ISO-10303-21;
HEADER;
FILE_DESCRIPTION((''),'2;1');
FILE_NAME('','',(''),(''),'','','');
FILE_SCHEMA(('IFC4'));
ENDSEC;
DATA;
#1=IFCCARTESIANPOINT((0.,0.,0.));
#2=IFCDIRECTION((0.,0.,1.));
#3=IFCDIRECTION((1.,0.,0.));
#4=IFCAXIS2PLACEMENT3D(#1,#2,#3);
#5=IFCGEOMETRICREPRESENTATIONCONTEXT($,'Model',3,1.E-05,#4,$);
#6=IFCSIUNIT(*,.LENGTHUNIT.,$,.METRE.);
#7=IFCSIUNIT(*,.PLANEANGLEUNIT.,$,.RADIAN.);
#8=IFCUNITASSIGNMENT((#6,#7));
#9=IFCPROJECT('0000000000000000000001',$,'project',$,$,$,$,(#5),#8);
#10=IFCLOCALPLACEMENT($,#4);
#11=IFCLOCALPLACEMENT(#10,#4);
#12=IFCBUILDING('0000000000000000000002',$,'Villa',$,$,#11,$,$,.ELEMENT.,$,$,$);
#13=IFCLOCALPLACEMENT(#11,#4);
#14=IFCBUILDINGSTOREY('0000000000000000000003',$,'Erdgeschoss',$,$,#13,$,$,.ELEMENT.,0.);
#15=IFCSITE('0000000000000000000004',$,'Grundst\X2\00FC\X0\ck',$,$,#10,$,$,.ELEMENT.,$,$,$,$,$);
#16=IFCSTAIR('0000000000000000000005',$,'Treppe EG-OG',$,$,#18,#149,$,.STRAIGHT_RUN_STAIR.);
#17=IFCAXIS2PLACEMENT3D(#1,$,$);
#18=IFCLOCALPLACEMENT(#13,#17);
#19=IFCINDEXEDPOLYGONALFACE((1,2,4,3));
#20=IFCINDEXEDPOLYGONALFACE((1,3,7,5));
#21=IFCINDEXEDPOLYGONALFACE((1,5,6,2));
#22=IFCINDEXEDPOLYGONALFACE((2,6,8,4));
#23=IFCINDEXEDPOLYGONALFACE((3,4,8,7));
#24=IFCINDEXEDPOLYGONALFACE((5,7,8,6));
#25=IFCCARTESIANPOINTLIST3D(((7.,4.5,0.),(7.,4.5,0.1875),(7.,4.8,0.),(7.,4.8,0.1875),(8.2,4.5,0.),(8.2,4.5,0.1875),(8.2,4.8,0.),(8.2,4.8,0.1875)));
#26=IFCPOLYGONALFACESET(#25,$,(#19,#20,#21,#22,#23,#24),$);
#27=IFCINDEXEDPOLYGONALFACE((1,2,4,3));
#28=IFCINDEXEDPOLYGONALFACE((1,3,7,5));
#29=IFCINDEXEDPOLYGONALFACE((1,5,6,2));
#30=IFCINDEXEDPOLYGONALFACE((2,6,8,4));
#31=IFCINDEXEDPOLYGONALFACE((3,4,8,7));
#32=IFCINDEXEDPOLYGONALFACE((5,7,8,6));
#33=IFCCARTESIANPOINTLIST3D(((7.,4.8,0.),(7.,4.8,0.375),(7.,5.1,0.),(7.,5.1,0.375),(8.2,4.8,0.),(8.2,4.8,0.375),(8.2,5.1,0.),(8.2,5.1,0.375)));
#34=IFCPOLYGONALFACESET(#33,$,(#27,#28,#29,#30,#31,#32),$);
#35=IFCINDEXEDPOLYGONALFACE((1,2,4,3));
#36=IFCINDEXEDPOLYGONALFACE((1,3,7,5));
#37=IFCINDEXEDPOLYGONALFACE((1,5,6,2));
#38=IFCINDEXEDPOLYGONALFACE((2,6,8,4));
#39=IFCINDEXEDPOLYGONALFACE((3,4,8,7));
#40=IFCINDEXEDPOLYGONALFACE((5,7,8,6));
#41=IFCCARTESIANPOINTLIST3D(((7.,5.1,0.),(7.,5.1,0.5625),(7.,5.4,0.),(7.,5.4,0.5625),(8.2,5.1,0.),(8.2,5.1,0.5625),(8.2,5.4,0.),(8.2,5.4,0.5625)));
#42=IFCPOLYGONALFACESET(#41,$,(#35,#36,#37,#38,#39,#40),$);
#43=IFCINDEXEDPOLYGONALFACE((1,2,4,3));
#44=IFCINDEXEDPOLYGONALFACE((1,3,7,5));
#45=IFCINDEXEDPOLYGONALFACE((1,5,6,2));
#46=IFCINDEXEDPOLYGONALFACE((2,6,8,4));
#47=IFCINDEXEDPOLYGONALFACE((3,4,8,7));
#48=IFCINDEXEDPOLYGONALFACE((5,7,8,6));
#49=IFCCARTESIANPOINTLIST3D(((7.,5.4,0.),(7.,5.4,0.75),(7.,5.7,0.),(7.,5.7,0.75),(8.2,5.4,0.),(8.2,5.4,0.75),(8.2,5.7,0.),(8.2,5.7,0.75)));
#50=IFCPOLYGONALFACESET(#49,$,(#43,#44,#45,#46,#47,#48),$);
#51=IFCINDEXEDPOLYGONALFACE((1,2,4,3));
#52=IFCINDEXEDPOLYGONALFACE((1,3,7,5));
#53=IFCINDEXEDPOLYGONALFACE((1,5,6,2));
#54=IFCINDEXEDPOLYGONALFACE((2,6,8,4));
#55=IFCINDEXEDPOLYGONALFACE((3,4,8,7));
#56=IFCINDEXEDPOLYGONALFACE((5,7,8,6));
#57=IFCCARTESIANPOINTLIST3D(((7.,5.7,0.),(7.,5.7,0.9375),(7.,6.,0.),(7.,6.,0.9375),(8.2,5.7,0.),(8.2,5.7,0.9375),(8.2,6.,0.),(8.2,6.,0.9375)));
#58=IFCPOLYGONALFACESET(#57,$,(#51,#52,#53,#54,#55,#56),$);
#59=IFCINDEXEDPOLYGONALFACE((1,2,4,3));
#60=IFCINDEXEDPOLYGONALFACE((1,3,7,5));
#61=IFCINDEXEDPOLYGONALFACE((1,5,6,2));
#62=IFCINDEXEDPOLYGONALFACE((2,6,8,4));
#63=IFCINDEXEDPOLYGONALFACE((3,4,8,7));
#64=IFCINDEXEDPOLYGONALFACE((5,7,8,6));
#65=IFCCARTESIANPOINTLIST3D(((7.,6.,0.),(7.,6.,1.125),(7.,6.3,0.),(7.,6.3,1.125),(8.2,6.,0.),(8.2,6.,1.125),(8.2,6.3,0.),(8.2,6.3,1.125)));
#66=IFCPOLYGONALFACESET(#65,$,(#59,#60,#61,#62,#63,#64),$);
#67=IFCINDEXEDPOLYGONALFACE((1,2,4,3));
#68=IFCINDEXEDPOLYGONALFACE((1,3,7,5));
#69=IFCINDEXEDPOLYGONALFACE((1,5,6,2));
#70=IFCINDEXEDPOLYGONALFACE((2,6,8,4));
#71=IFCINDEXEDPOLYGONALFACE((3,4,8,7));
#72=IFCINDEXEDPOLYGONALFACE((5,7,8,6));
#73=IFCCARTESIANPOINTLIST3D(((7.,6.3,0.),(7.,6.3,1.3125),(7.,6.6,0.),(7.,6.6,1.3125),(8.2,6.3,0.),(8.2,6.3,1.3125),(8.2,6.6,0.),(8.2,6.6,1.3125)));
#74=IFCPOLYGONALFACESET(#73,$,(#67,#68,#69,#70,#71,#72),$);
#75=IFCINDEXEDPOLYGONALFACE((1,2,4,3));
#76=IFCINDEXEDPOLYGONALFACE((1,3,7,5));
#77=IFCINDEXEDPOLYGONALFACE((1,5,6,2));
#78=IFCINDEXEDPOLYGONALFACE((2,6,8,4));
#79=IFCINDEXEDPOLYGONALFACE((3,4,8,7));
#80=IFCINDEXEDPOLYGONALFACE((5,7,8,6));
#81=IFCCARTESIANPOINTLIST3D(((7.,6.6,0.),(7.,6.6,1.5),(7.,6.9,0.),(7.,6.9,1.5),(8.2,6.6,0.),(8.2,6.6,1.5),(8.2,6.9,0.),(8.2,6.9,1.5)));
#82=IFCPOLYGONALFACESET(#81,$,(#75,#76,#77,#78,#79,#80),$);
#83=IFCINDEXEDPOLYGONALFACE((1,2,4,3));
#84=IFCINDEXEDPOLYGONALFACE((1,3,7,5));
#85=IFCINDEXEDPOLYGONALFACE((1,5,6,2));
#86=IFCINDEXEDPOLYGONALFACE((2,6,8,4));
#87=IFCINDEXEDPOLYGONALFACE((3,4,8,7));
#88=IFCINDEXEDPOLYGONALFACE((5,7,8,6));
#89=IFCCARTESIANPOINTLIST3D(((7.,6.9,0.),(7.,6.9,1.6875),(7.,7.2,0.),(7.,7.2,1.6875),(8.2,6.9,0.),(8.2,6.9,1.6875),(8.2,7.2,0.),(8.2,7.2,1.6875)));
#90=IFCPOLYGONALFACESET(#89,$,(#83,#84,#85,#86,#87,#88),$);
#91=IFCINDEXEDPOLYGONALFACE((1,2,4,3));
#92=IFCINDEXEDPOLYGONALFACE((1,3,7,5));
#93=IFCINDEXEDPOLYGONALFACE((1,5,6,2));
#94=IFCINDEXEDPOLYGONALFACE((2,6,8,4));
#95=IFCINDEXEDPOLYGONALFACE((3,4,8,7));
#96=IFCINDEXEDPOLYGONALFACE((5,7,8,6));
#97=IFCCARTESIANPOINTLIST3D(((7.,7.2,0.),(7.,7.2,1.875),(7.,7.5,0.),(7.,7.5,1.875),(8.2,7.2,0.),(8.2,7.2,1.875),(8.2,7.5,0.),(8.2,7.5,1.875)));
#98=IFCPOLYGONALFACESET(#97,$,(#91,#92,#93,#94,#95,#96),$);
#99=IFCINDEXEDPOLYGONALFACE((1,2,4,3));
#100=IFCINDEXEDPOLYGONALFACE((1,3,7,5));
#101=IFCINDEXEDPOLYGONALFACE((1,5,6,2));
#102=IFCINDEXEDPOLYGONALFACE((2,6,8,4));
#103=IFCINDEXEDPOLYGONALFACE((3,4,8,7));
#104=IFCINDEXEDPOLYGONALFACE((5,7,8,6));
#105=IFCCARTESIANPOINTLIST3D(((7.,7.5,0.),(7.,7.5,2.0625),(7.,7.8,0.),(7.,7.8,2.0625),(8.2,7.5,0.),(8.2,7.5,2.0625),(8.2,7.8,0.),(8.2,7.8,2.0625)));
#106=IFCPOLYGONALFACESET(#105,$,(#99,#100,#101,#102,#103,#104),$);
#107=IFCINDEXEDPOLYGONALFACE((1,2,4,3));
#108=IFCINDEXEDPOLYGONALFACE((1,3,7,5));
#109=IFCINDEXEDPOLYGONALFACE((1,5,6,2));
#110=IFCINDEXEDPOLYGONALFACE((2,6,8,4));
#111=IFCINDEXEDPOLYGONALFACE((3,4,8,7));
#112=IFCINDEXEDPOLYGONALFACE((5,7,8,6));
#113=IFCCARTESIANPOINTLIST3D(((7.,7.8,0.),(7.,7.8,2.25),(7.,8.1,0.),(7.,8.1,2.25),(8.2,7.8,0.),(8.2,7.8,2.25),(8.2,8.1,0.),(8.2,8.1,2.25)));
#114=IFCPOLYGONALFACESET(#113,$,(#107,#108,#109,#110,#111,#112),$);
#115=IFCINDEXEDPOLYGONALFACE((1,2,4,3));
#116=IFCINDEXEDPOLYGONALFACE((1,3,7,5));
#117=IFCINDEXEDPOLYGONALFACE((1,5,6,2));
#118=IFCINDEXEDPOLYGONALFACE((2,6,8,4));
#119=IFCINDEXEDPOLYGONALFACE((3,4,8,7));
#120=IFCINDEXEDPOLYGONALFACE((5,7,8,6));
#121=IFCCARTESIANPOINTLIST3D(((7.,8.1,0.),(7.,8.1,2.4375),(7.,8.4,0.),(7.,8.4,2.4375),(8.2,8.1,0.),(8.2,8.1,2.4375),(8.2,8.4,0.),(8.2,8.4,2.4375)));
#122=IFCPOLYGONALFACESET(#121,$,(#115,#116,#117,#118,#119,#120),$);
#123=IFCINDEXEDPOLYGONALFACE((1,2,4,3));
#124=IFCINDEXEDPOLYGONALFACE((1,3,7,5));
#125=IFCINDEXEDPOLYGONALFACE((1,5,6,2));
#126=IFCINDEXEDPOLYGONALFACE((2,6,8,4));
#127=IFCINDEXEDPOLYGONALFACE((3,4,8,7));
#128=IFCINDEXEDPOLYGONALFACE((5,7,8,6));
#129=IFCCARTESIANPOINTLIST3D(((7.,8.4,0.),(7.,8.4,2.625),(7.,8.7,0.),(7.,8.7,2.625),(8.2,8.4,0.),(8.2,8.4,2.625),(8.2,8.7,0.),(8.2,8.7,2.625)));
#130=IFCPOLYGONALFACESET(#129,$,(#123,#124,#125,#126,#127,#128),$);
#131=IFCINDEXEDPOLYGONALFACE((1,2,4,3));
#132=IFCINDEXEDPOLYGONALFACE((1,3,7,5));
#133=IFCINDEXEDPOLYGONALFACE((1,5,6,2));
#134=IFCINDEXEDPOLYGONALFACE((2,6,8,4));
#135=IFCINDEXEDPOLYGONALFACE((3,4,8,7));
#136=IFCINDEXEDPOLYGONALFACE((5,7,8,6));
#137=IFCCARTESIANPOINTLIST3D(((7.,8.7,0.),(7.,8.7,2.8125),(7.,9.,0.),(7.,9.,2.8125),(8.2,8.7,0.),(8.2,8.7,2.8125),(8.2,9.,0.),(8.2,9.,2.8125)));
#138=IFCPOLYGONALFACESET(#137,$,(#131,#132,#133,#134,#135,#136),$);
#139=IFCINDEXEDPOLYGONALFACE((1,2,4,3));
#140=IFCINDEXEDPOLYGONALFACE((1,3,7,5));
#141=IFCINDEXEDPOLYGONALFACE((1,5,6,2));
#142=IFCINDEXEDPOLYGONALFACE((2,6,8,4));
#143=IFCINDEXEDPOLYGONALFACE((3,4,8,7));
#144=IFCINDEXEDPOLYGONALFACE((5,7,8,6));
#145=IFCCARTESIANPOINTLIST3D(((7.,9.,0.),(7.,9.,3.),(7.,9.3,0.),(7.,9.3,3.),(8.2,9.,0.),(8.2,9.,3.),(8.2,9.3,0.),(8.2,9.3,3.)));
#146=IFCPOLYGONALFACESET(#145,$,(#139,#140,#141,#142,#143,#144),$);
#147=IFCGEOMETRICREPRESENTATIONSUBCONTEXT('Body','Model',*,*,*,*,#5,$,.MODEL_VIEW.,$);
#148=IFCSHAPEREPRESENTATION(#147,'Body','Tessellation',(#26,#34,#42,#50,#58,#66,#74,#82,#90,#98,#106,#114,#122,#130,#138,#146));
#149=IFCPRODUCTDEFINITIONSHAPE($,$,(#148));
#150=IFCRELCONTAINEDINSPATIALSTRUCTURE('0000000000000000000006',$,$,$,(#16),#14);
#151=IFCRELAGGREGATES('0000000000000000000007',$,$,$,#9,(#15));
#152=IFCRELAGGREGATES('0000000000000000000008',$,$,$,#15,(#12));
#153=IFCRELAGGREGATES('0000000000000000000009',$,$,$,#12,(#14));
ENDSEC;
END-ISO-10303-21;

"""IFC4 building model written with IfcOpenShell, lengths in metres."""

from ifc_helpers import new_model, si_unit, frame_2d, origin_with_axes, place, context, subcontext, project, spatial, rectangle, extrude, element, save


model = new_model("IFC4")

# Units and contexts
model_context = context("Model", 3, precision=1e-05, world=origin_with_axes())
body_context = subcontext(model_context, "Body", "Model", "MODEL_VIEW")
ifc_project = project(units=[si_unit("LENGTHUNIT", "METRE"), si_unit("PLANEANGLEUNIT", "RADIAN")], contexts=[model_context])

# Site, building, storey
site_placement = place(None, origin_with_axes())
site = spatial("IfcSite", under=ifc_project, at=site_placement, Name="Grundstück", CompositionType="ELEMENT")
building_placement = place(site_placement, origin_with_axes())
building = spatial("IfcBuilding", under=site, at=building_placement, Name="Villa", CompositionType="ELEMENT")
storey_placement = place(building_placement, origin_with_axes())
storey = spatial("IfcBuildingStorey", under=building, at=storey_placement, Name="Erdgeschoss", CompositionType="ELEMENT", Elevation=0.0)

# Stair
stair_placement = place(storey_placement, origin_with_axes())
element("IfcStair", 1, at=stair_placement, inside=storey, Name="Treppe EG-OG", PredefinedType="STRAIGHT_RUN_STAIR", context=body_context, shape_type="SweptSolid", body=[
    extrude(rectangle(XDim=1.2, YDim=0.3, at=frame_2d((7.6, 4.65))), origin_with_axes(), (0.0, 0.0, 1.0), 0.1875),
    extrude(rectangle(XDim=1.2, YDim=0.3, at=frame_2d((7.6, 4.95))), origin_with_axes(), (0.0, 0.0, 1.0), 0.375),
    extrude(rectangle(XDim=1.2, YDim=0.3, at=frame_2d((7.6, 5.25))), origin_with_axes(), (0.0, 0.0, 1.0), 0.5625),
    extrude(rectangle(XDim=1.2, YDim=0.3, at=frame_2d((7.6, 5.55))), origin_with_axes(), (0.0, 0.0, 1.0), 0.75),
    extrude(rectangle(XDim=1.2, YDim=0.3, at=frame_2d((7.6, 5.85))), origin_with_axes(), (0.0, 0.0, 1.0), 0.9375),
    extrude(rectangle(XDim=1.2, YDim=0.3, at=frame_2d((7.6, 6.15))), origin_with_axes(), (0.0, 0.0, 1.0), 1.125),
    extrude(rectangle(XDim=1.2, YDim=0.3, at=frame_2d((7.6, 6.45))), origin_with_axes(), (0.0, 0.0, 1.0), 1.3125),
    extrude(rectangle(XDim=1.2, YDim=0.3, at=frame_2d((7.6, 6.75))), origin_with_axes(), (0.0, 0.0, 1.0), 1.5),
    extrude(rectangle(XDim=1.2, YDim=0.3, at=frame_2d((7.6, 7.05))), origin_with_axes(), (0.0, 0.0, 1.0), 1.6875),
    extrude(rectangle(XDim=1.2, YDim=0.3, at=frame_2d((7.6, 7.35))), origin_with_axes(), (0.0, 0.0, 1.0), 1.875),
    extrude(rectangle(XDim=1.2, YDim=0.3, at=frame_2d((7.6, 7.65))), origin_with_axes(), (0.0, 0.0, 1.0), 2.0625),
    extrude(rectangle(XDim=1.2, YDim=0.3, at=frame_2d((7.6, 7.95))), origin_with_axes(), (0.0, 0.0, 1.0), 2.25),
    extrude(rectangle(XDim=1.2, YDim=0.3, at=frame_2d((7.6, 8.25))), origin_with_axes(), (0.0, 0.0, 1.0), 2.4375),
    extrude(rectangle(XDim=1.2, YDim=0.3, at=frame_2d((7.6, 8.55))), origin_with_axes(), (0.0, 0.0, 1.0), 2.625),
    extrude(rectangle(XDim=1.2, YDim=0.3, at=frame_2d((7.6, 8.85))), origin_with_axes(), (0.0, 0.0, 1.0), 2.8125),
    extrude(rectangle(XDim=1.2, YDim=0.3, at=frame_2d((7.6, 9.15))), origin_with_axes(), (0.0, 0.0, 1.0), 3.0),
])

save(model, "model.ifc")
